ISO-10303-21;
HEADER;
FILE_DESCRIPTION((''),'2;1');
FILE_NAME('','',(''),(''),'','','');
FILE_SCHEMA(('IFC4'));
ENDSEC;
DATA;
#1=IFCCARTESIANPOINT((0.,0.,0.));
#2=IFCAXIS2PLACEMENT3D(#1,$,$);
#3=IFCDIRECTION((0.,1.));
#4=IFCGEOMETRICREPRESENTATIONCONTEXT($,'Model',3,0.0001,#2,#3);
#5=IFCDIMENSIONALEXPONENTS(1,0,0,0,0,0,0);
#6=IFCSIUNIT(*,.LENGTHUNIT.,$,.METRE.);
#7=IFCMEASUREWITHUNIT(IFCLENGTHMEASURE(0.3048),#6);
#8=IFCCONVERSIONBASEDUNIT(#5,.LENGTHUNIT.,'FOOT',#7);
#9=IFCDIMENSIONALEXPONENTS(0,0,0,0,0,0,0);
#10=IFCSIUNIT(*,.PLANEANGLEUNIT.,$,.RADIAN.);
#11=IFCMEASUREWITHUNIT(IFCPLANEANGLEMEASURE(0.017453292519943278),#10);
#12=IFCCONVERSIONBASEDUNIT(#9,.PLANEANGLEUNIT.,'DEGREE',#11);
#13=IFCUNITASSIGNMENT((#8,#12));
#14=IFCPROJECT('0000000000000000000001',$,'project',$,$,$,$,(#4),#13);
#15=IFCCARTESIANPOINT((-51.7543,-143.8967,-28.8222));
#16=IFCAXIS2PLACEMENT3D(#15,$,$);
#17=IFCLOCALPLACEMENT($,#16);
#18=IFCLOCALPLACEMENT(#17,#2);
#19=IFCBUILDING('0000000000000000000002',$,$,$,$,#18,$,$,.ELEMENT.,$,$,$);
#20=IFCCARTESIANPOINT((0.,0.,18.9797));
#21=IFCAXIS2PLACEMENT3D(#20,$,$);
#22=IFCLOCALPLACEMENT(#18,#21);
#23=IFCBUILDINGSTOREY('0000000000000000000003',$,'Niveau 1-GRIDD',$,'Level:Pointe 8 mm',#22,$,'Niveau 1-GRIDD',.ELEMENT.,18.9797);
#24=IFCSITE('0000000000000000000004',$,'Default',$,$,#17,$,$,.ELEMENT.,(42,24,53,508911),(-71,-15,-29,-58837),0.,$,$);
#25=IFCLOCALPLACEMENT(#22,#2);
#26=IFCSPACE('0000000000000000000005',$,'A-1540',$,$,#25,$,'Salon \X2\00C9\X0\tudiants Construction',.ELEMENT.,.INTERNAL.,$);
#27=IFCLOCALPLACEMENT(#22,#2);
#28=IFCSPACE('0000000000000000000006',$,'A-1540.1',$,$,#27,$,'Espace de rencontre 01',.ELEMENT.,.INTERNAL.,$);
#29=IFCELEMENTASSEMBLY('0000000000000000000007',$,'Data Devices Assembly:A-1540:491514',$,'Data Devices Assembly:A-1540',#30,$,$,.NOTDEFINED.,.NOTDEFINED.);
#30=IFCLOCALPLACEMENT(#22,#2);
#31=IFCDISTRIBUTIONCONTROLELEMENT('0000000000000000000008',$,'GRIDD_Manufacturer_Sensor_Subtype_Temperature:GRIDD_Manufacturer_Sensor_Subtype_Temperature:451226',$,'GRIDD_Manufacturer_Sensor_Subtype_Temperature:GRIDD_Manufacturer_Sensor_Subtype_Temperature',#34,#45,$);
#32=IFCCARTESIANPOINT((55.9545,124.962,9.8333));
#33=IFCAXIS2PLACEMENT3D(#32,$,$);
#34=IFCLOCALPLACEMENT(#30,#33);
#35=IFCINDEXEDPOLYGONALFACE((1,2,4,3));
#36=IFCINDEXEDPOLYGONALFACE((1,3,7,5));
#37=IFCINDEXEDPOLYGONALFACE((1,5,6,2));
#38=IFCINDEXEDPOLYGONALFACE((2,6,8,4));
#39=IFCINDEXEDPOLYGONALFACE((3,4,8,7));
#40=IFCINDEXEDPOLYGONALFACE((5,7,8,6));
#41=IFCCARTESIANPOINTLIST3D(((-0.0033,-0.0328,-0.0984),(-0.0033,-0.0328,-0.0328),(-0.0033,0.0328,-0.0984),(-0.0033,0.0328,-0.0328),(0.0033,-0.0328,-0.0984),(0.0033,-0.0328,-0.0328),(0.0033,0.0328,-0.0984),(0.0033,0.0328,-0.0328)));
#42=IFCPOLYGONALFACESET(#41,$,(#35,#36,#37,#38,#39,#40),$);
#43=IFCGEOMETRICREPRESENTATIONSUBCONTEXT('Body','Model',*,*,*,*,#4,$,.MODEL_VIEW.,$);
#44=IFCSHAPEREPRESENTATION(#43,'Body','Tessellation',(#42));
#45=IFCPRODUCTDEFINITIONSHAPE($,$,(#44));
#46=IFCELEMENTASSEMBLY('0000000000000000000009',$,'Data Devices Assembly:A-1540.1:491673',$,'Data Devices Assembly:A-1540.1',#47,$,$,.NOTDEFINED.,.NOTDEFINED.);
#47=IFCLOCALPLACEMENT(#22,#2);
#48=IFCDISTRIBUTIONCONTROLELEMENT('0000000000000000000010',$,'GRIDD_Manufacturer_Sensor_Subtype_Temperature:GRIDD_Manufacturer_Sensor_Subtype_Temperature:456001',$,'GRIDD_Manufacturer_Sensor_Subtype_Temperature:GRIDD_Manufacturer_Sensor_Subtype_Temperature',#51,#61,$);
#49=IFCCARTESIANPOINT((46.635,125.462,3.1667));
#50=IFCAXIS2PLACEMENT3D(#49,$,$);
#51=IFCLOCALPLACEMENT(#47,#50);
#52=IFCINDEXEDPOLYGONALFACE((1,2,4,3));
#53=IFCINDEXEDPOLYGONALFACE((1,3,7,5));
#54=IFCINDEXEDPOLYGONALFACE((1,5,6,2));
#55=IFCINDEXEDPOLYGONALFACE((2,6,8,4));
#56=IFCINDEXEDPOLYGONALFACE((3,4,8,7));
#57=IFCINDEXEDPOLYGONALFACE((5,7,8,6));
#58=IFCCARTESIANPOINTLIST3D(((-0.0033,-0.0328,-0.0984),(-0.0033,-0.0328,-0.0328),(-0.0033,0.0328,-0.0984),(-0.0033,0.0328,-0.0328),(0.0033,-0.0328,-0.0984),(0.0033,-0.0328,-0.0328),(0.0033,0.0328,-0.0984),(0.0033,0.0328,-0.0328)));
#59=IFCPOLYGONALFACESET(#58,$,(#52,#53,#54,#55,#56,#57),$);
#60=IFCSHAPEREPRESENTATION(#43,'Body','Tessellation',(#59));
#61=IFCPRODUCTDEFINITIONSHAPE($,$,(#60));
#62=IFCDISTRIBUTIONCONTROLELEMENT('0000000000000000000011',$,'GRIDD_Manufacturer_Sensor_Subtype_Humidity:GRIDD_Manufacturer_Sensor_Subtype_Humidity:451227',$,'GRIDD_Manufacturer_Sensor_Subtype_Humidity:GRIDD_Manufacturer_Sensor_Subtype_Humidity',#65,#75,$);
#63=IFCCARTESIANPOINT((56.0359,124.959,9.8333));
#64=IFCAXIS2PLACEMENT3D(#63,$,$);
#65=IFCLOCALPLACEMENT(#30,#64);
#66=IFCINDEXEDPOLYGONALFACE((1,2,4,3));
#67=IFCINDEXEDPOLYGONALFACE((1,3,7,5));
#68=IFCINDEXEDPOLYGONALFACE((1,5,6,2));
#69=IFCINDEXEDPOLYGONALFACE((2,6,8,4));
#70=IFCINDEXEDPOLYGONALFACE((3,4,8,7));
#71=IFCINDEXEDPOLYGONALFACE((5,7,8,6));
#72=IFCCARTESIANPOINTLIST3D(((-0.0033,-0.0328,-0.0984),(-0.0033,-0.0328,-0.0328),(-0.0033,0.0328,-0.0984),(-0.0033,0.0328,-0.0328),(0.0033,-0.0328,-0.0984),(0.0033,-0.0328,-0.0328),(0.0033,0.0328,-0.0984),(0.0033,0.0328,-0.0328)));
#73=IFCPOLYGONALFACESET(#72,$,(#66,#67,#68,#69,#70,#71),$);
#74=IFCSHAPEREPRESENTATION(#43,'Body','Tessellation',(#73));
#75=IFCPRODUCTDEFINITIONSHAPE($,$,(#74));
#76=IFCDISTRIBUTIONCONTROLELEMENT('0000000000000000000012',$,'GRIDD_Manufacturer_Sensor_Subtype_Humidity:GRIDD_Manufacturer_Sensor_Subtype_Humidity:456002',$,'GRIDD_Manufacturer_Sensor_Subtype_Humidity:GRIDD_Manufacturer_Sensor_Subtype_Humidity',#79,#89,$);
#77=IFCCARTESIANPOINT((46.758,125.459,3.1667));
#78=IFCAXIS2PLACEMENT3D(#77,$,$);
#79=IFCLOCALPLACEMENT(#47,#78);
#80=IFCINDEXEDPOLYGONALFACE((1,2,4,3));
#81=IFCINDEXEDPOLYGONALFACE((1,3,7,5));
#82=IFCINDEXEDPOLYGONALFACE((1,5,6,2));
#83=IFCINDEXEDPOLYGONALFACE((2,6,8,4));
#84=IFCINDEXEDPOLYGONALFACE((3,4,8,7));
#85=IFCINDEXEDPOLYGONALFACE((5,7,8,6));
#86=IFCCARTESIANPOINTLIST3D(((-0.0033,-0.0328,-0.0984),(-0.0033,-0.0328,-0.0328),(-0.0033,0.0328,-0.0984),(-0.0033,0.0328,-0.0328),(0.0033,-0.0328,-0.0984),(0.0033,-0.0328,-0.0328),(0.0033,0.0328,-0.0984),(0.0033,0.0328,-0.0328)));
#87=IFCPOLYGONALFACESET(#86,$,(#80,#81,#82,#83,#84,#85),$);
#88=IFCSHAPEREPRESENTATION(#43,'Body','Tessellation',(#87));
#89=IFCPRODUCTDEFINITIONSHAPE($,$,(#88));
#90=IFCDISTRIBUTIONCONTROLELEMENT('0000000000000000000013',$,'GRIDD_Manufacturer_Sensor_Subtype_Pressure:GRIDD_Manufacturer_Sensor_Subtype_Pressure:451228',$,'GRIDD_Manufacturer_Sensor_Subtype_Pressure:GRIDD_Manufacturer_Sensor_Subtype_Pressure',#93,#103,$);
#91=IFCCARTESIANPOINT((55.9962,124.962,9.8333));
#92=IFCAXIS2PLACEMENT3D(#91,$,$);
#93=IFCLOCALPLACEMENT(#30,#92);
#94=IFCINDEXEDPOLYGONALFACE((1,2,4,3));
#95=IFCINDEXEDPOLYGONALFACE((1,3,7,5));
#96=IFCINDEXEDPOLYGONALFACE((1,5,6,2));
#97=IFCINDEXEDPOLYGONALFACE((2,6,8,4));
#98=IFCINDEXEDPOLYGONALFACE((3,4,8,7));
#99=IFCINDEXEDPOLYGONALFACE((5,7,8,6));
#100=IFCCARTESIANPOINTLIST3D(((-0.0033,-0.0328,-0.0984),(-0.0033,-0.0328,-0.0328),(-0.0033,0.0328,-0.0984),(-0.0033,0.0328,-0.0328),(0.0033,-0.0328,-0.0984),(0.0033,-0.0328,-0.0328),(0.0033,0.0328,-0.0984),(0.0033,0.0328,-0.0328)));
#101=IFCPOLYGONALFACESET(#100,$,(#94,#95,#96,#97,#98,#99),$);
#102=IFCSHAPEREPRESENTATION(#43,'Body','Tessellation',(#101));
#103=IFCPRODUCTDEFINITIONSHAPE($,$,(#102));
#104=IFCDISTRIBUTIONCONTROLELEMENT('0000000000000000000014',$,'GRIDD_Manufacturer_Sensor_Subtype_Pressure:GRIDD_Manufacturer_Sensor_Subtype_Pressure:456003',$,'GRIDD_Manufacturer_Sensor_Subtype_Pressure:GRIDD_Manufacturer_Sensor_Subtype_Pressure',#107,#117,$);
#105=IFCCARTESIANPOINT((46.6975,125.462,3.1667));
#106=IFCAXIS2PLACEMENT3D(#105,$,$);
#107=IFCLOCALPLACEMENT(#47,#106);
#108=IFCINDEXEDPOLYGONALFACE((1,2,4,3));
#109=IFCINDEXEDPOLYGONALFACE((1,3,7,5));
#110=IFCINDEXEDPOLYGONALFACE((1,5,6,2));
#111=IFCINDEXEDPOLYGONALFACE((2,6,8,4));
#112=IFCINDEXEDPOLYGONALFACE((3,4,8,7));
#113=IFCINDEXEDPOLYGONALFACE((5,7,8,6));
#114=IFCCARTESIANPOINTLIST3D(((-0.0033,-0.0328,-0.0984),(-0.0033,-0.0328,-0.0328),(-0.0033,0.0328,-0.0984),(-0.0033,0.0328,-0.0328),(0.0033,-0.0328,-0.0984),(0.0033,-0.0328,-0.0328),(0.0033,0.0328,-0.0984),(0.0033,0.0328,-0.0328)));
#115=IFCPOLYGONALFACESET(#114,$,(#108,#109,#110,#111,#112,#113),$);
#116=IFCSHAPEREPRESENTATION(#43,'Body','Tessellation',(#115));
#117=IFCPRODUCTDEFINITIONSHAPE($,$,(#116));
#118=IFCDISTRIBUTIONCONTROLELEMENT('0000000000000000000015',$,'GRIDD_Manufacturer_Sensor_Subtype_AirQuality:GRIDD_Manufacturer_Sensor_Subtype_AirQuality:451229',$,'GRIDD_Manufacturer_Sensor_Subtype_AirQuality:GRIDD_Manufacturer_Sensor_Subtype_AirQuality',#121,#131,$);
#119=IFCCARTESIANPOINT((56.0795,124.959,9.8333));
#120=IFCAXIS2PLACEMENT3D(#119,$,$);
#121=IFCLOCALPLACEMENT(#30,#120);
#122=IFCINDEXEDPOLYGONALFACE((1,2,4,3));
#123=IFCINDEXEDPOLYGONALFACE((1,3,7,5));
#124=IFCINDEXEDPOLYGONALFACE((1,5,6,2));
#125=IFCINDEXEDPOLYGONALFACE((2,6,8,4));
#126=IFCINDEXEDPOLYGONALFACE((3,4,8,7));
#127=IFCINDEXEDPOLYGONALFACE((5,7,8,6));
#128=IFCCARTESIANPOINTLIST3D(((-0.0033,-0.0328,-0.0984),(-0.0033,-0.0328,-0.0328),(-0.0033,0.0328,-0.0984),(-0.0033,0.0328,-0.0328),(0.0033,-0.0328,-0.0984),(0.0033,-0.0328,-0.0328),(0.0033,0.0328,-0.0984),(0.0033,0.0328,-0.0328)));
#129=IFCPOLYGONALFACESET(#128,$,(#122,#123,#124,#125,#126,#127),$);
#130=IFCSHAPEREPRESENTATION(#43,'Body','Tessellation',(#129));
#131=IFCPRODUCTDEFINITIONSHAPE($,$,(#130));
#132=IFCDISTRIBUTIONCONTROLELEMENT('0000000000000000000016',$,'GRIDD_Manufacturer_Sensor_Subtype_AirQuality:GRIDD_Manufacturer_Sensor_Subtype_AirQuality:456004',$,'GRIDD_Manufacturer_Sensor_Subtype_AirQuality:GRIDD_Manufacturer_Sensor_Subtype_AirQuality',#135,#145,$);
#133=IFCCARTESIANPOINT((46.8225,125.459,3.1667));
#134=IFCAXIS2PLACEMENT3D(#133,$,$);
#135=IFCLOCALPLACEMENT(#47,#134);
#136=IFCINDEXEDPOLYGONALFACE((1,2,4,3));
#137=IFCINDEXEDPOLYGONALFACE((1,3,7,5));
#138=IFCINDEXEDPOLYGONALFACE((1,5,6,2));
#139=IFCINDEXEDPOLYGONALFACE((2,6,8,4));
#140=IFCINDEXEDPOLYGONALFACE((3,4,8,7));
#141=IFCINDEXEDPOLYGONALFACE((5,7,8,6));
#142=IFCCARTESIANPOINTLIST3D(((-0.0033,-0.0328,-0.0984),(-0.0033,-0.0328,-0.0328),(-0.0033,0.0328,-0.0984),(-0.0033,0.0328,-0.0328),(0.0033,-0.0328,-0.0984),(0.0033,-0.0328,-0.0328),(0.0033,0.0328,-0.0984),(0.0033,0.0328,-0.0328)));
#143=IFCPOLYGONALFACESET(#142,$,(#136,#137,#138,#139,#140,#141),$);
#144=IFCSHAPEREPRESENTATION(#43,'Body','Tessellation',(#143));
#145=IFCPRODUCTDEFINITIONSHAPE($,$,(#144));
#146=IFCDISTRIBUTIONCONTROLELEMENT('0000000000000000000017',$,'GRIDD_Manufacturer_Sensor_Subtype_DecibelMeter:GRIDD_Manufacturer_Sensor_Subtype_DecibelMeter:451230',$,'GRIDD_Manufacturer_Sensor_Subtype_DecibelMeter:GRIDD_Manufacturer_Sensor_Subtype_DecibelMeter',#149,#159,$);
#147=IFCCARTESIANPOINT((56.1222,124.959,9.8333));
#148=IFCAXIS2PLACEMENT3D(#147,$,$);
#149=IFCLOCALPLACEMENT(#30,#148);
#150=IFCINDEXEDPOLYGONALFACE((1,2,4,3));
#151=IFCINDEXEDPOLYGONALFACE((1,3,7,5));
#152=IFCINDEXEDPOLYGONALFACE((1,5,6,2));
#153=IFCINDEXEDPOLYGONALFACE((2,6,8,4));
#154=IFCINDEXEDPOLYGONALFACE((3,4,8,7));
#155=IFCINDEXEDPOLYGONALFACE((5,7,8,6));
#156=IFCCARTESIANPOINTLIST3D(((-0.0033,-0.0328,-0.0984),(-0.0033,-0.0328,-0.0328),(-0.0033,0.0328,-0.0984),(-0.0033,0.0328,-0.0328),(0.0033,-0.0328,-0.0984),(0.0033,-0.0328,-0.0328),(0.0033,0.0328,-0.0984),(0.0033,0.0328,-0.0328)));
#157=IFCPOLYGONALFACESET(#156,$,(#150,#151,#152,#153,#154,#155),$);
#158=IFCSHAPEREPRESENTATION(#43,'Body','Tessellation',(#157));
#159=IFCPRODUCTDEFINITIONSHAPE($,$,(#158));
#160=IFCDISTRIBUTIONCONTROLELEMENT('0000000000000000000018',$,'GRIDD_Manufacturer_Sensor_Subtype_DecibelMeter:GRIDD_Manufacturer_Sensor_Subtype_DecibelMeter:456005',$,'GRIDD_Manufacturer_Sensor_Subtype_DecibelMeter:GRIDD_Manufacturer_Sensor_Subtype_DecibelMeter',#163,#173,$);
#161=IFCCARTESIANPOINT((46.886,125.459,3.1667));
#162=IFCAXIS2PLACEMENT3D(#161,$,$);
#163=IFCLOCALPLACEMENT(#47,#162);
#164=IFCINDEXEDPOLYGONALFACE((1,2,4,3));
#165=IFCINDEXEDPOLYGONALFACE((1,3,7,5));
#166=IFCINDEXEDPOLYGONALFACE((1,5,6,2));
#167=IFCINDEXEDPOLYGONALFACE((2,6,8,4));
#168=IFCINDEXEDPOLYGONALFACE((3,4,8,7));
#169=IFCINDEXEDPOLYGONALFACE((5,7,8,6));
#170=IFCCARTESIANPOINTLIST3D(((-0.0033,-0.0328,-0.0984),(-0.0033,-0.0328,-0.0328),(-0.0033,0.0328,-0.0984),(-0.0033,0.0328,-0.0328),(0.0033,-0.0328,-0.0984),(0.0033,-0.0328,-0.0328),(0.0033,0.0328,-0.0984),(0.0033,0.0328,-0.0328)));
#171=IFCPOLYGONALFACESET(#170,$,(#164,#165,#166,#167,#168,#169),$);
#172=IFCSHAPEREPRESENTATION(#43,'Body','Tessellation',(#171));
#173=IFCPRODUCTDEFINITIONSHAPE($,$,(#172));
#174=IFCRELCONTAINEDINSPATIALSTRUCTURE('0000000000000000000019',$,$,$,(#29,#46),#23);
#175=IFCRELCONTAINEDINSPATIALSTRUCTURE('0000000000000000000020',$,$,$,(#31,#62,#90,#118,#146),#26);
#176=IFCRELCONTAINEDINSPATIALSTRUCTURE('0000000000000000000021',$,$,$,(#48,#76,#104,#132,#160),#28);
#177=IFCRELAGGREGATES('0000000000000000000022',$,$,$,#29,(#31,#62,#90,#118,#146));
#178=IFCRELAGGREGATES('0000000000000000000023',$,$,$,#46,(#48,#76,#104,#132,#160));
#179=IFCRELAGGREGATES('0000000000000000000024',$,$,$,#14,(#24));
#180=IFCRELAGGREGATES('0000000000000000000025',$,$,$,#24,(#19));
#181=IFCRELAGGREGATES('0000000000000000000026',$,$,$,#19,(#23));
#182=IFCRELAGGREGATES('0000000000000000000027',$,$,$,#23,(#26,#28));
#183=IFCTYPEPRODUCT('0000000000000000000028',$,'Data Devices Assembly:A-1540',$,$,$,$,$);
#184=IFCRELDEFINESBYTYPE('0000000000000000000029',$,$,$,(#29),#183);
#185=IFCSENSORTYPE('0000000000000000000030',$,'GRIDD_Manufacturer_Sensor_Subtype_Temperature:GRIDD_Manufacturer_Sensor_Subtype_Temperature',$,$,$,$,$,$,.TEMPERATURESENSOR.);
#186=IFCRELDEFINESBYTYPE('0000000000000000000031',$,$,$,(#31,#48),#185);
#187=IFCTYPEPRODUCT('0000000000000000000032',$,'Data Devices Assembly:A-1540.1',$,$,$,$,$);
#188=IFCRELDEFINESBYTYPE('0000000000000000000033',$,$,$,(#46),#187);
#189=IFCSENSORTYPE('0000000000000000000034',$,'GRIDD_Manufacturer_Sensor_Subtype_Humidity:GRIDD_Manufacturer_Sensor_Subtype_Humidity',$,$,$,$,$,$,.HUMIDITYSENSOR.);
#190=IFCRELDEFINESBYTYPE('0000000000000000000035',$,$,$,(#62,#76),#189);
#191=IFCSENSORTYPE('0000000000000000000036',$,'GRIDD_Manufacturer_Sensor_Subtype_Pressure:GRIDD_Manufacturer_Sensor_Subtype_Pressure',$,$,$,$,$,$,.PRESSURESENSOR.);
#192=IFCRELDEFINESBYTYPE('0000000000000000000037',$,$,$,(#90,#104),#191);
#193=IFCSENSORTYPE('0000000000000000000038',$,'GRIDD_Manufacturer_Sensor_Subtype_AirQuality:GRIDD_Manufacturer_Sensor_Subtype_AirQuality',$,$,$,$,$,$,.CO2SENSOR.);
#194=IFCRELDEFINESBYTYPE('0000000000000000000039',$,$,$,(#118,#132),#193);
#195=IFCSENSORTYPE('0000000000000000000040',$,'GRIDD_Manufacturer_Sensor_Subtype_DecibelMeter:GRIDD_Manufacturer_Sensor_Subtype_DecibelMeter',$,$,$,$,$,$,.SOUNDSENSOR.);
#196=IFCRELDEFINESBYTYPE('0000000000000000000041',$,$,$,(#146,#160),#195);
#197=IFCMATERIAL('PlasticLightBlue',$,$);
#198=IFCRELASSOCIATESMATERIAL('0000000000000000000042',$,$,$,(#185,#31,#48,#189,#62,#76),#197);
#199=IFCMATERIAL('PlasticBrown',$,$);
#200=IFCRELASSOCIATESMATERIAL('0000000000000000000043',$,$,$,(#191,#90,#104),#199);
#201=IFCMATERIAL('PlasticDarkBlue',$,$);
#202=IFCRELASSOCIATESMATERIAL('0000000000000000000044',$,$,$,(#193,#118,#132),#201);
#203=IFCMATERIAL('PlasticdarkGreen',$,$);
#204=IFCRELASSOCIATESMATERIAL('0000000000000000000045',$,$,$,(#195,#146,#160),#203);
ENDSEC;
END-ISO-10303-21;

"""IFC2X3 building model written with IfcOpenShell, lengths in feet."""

from ifc_helpers import new_model, entity, si_unit, converted_unit, direction, frame, origin, origin_2d_with_axis, place, context, subcontext, project, spatial, rectangle, extrude, source, transform, mapped, material, type_object, type_shapes, element, aggregate, save


model = new_model("IFC2X3")

# Units and contexts
model_context = context("Model", 3, precision=0.0001, world=origin(), true_north=direction((0.0, 1.0)))
body_context = subcontext(model_context, "Body", "Model", "MODEL_VIEW")
ifc_project = project(units=[converted_unit("LENGTHUNIT", "FOOT", entity("IfcLengthMeasure", 0.3048), si_unit("LENGTHUNIT", "METRE"), dimensions=[1, 0, 0, 0, 0, 0, 0]), converted_unit("PLANEANGLEUNIT", "DEGREE", entity("IfcPlaneAngleMeasure", 0.017453292519943278), si_unit("PLANEANGLEUNIT", "RADIAN"), dimensions=[0, 0, 0, 0, 0, 0, 0])], contexts=[model_context])

# Site, building, storey
site_placement = place(None, frame((-51.7543, -143.8967, -28.8222)))
site = spatial("IfcSite", under=ifc_project, at=site_placement, Name="Default", CompositionType="ELEMENT", RefLatitude=(42, 24, 53, 508911), RefLongitude=(-71, -15, -29, -58837), RefElevation=0.0)
building_placement = place(site_placement, origin())
building = spatial("IfcBuilding", under=site, at=building_placement, CompositionType="ELEMENT")
storey_placement = place(building_placement, frame((0.0, 0.0, 18.9797)))
storey = spatial("IfcBuildingStorey", under=building, at=storey_placement, Name="Niveau 1-GRIDD", ObjectType="Level:Pointe 8 mm", LongName="Niveau 1-GRIDD", CompositionType="ELEMENT", Elevation=18.9797)

# Shared definitions
space_1_placement = place(storey_placement, origin())
space_1 = spatial("IfcSpace", under=storey, at=space_1_placement, Name="A-1540", LongName="Salon Étudiants Construction", CompositionType="ELEMENT", InteriorOrExteriorSpace="INTERNAL")

# Element assembly, distribution control element
type_product_1 = type_object("IfcTypeProduct", Name="Data Devices Assembly:A-1540")
assembly_1_placement = place(storey_placement, origin())
assembly_1 = element("IfcElementAssembly", 1, at=assembly_1_placement, inside=storey, type_object=type_product_1, Name="Data Devices Assembly:A-1540:491514", ObjectType="Data Devices Assembly:A-1540", AssemblyPlace="NOTDEFINED", PredefinedType="NOTDEFINED")
ifc_material_1 = material(Name="PlasticLightBlue")
sensor_type_1 = type_object("IfcSensorType", Name="GRIDD_Manufacturer_Sensor_Subtype_Temperature:GRIDD_Manufacturer_Sensor_Subtype_Temperature", PredefinedType="TEMPERATURESENSOR", material=ifc_material_1)
shared_shape_1 = source(origin(), body_context, "Body", "SweptSolid", [
    extrude(rectangle(XDim=0.0066, YDim=0.0656, at=origin_2d_with_axis()), frame((0.0, 0.0, -0.0984), z_axis=(0.0, 0.0, 1.0), x_axis=(-1.0, 0.0, 0.0)), (0.0, 0.0, 1.0), 0.0656),
])
type_shapes(sensor_type_1, [shared_shape_1])
distribution_control_element_1_placement = place(assembly_1_placement, frame((55.9545, 124.962, 9.8333)))
distribution_control_element_1 = element("IfcDistributionControlElement", 2, at=distribution_control_element_1_placement, inside=space_1, type_object=sensor_type_1, material=ifc_material_1, Name="GRIDD_Manufacturer_Sensor_Subtype_Temperature:GRIDD_Manufacturer_Sensor_Subtype_Temperature:451226", ObjectType="GRIDD_Manufacturer_Sensor_Subtype_Temperature:GRIDD_Manufacturer_Sensor_Subtype_Temperature", context=body_context, shape_type="MappedRepresentation", body=[
    mapped(shared_shape_1, transform((0.0, 0.0, 0.0), scale=1.0)),
])

# Element assembly
type_product_2 = type_object("IfcTypeProduct", Name="Data Devices Assembly:A-1540.1")
assembly_2_placement = place(storey_placement, origin())
assembly_2 = element("IfcElementAssembly", 3, at=assembly_2_placement, inside=storey, type_object=type_product_2, Name="Data Devices Assembly:A-1540.1:491673", ObjectType="Data Devices Assembly:A-1540.1", AssemblyPlace="NOTDEFINED", PredefinedType="NOTDEFINED")

# Shared definitions
space_2_placement = place(storey_placement, origin())
space_2 = spatial("IfcSpace", under=storey, at=space_2_placement, Name="A-1540.1", LongName="Espace de rencontre 01", CompositionType="ELEMENT", InteriorOrExteriorSpace="INTERNAL")

# Distribution control elements
distribution_control_element_2_placement = place(assembly_2_placement, frame((46.635, 125.462, 3.1667)))
distribution_control_element_2 = element("IfcDistributionControlElement", 4, at=distribution_control_element_2_placement, inside=space_2, type_object=sensor_type_1, material=ifc_material_1, Name="GRIDD_Manufacturer_Sensor_Subtype_Temperature:GRIDD_Manufacturer_Sensor_Subtype_Temperature:456001", ObjectType="GRIDD_Manufacturer_Sensor_Subtype_Temperature:GRIDD_Manufacturer_Sensor_Subtype_Temperature", context=body_context, shape_type="MappedRepresentation", body=[
    mapped(shared_shape_1, transform((0.0, 0.0, 0.0), scale=1.0)),
])
sensor_type_2 = type_object("IfcSensorType", Name="GRIDD_Manufacturer_Sensor_Subtype_Humidity:GRIDD_Manufacturer_Sensor_Subtype_Humidity", PredefinedType="HUMIDITYSENSOR", material=ifc_material_1)
shared_shape_2 = source(origin(), body_context, "Body", "SweptSolid", [
    extrude(rectangle(XDim=0.0066, YDim=0.0656, at=origin_2d_with_axis()), frame((0.0, 0.0, -0.0984), z_axis=(0.0, 0.0, 1.0), x_axis=(-1.0, 0.0, 0.0)), (0.0, 0.0, 1.0), 0.0656),
])
type_shapes(sensor_type_2, [shared_shape_2])
distribution_control_element_3_placement = place(assembly_1_placement, frame((56.0359, 124.959, 9.8333)))
distribution_control_element_3 = element("IfcDistributionControlElement", 5, at=distribution_control_element_3_placement, inside=space_1, type_object=sensor_type_2, material=ifc_material_1, Name="GRIDD_Manufacturer_Sensor_Subtype_Humidity:GRIDD_Manufacturer_Sensor_Subtype_Humidity:451227", ObjectType="GRIDD_Manufacturer_Sensor_Subtype_Humidity:GRIDD_Manufacturer_Sensor_Subtype_Humidity", context=body_context, shape_type="MappedRepresentation", body=[
    mapped(shared_shape_2, transform((0.0, 0.0, 0.0), scale=1.0)),
])
distribution_control_element_4_placement = place(assembly_2_placement, frame((46.758, 125.459, 3.1667)))
distribution_control_element_4 = element("IfcDistributionControlElement", 6, at=distribution_control_element_4_placement, inside=space_2, type_object=sensor_type_2, material=ifc_material_1, Name="GRIDD_Manufacturer_Sensor_Subtype_Humidity:GRIDD_Manufacturer_Sensor_Subtype_Humidity:456002", ObjectType="GRIDD_Manufacturer_Sensor_Subtype_Humidity:GRIDD_Manufacturer_Sensor_Subtype_Humidity", context=body_context, shape_type="MappedRepresentation", body=[
    mapped(shared_shape_2, transform((0.0, 0.0, 0.0), scale=1.0)),
])
ifc_material_2 = material(Name="PlasticBrown")
sensor_type_3 = type_object("IfcSensorType", Name="GRIDD_Manufacturer_Sensor_Subtype_Pressure:GRIDD_Manufacturer_Sensor_Subtype_Pressure", PredefinedType="PRESSURESENSOR", material=ifc_material_2)
shared_shape_3 = source(origin(), body_context, "Body", "SweptSolid", [
    extrude(rectangle(XDim=0.0066, YDim=0.0656, at=origin_2d_with_axis()), frame((0.0, 0.0, -0.0984), z_axis=(0.0, 0.0, 1.0), x_axis=(-1.0, 0.0, 0.0)), (0.0, 0.0, 1.0), 0.0656),
])
type_shapes(sensor_type_3, [shared_shape_3])
distribution_control_element_5_placement = place(assembly_1_placement, frame((55.9962, 124.962, 9.8333)))
distribution_control_element_5 = element("IfcDistributionControlElement", 7, at=distribution_control_element_5_placement, inside=space_1, type_object=sensor_type_3, material=ifc_material_2, Name="GRIDD_Manufacturer_Sensor_Subtype_Pressure:GRIDD_Manufacturer_Sensor_Subtype_Pressure:451228", ObjectType="GRIDD_Manufacturer_Sensor_Subtype_Pressure:GRIDD_Manufacturer_Sensor_Subtype_Pressure", context=body_context, shape_type="MappedRepresentation", body=[
    mapped(shared_shape_3, transform((0.0, 0.0, 0.0), scale=1.0)),
])
distribution_control_element_6_placement = place(assembly_2_placement, frame((46.6975, 125.462, 3.1667)))
distribution_control_element_6 = element("IfcDistributionControlElement", 8, at=distribution_control_element_6_placement, inside=space_2, type_object=sensor_type_3, material=ifc_material_2, Name="GRIDD_Manufacturer_Sensor_Subtype_Pressure:GRIDD_Manufacturer_Sensor_Subtype_Pressure:456003", ObjectType="GRIDD_Manufacturer_Sensor_Subtype_Pressure:GRIDD_Manufacturer_Sensor_Subtype_Pressure", context=body_context, shape_type="MappedRepresentation", body=[
    mapped(shared_shape_3, transform((0.0, 0.0, 0.0), scale=1.0)),
])
ifc_material_3 = material(Name="PlasticDarkBlue")
sensor_type_4 = type_object("IfcSensorType", Name="GRIDD_Manufacturer_Sensor_Subtype_AirQuality:GRIDD_Manufacturer_Sensor_Subtype_AirQuality", PredefinedType="CO2SENSOR", material=ifc_material_3)
shared_shape_4 = source(origin(), body_context, "Body", "SweptSolid", [
    extrude(rectangle(XDim=0.0066, YDim=0.0656, at=origin_2d_with_axis()), frame((0.0, 0.0, -0.0984), z_axis=(0.0, 0.0, 1.0), x_axis=(-1.0, 0.0, 0.0)), (0.0, 0.0, 1.0), 0.0656),
])
type_shapes(sensor_type_4, [shared_shape_4])
distribution_control_element_7_placement = place(assembly_1_placement, frame((56.0795, 124.959, 9.8333)))
distribution_control_element_7 = element("IfcDistributionControlElement", 9, at=distribution_control_element_7_placement, inside=space_1, type_object=sensor_type_4, material=ifc_material_3, Name="GRIDD_Manufacturer_Sensor_Subtype_AirQuality:GRIDD_Manufacturer_Sensor_Subtype_AirQuality:451229", ObjectType="GRIDD_Manufacturer_Sensor_Subtype_AirQuality:GRIDD_Manufacturer_Sensor_Subtype_AirQuality", context=body_context, shape_type="MappedRepresentation", body=[
    mapped(shared_shape_4, transform((0.0, 0.0, 0.0), scale=1.0)),
])
distribution_control_element_8_placement = place(assembly_2_placement, frame((46.8225, 125.459, 3.1667)))
distribution_control_element_8 = element("IfcDistributionControlElement", 10, at=distribution_control_element_8_placement, inside=space_2, type_object=sensor_type_4, material=ifc_material_3, Name="GRIDD_Manufacturer_Sensor_Subtype_AirQuality:GRIDD_Manufacturer_Sensor_Subtype_AirQuality:456004", ObjectType="GRIDD_Manufacturer_Sensor_Subtype_AirQuality:GRIDD_Manufacturer_Sensor_Subtype_AirQuality", context=body_context, shape_type="MappedRepresentation", body=[
    mapped(shared_shape_4, transform((0.0, 0.0, 0.0), scale=1.0)),
])
ifc_material_4 = material(Name="PlasticdarkGreen")
sensor_type_5 = type_object("IfcSensorType", Name="GRIDD_Manufacturer_Sensor_Subtype_DecibelMeter:GRIDD_Manufacturer_Sensor_Subtype_DecibelMeter", PredefinedType="SOUNDSENSOR", material=ifc_material_4)
shared_shape_5 = source(origin(), body_context, "Body", "SweptSolid", [
    extrude(rectangle(XDim=0.0066, YDim=0.0656, at=origin_2d_with_axis()), frame((0.0, 0.0, -0.0984), z_axis=(0.0, 0.0, 1.0), x_axis=(-1.0, 0.0, 0.0)), (0.0, 0.0, 1.0), 0.0656),
])
type_shapes(sensor_type_5, [shared_shape_5])
distribution_control_element_9_placement = place(assembly_1_placement, frame((56.1222, 124.959, 9.8333)))
distribution_control_element_9 = element("IfcDistributionControlElement", 11, at=distribution_control_element_9_placement, inside=space_1, type_object=sensor_type_5, material=ifc_material_4, Name="GRIDD_Manufacturer_Sensor_Subtype_DecibelMeter:GRIDD_Manufacturer_Sensor_Subtype_DecibelMeter:451230", ObjectType="GRIDD_Manufacturer_Sensor_Subtype_DecibelMeter:GRIDD_Manufacturer_Sensor_Subtype_DecibelMeter", context=body_context, shape_type="MappedRepresentation", body=[
    mapped(shared_shape_5, transform((0.0, 0.0, 0.0), scale=1.0)),
])
aggregate(assembly_1, [distribution_control_element_1, distribution_control_element_3, distribution_control_element_5, distribution_control_element_7, distribution_control_element_9])
distribution_control_element_10_placement = place(assembly_2_placement, frame((46.886, 125.459, 3.1667)))
distribution_control_element_10 = element("IfcDistributionControlElement", 12, at=distribution_control_element_10_placement, inside=space_2, type_object=sensor_type_5, material=ifc_material_4, Name="GRIDD_Manufacturer_Sensor_Subtype_DecibelMeter:GRIDD_Manufacturer_Sensor_Subtype_DecibelMeter:456005", ObjectType="GRIDD_Manufacturer_Sensor_Subtype_DecibelMeter:GRIDD_Manufacturer_Sensor_Subtype_DecibelMeter", context=body_context, shape_type="MappedRepresentation", body=[
    mapped(shared_shape_5, transform((0.0, 0.0, 0.0), scale=1.0)),
])
aggregate(assembly_2, [distribution_control_element_2, distribution_control_element_4, distribution_control_element_6, distribution_control_element_8, distribution_control_element_10])

save(model, "model.ifc")
